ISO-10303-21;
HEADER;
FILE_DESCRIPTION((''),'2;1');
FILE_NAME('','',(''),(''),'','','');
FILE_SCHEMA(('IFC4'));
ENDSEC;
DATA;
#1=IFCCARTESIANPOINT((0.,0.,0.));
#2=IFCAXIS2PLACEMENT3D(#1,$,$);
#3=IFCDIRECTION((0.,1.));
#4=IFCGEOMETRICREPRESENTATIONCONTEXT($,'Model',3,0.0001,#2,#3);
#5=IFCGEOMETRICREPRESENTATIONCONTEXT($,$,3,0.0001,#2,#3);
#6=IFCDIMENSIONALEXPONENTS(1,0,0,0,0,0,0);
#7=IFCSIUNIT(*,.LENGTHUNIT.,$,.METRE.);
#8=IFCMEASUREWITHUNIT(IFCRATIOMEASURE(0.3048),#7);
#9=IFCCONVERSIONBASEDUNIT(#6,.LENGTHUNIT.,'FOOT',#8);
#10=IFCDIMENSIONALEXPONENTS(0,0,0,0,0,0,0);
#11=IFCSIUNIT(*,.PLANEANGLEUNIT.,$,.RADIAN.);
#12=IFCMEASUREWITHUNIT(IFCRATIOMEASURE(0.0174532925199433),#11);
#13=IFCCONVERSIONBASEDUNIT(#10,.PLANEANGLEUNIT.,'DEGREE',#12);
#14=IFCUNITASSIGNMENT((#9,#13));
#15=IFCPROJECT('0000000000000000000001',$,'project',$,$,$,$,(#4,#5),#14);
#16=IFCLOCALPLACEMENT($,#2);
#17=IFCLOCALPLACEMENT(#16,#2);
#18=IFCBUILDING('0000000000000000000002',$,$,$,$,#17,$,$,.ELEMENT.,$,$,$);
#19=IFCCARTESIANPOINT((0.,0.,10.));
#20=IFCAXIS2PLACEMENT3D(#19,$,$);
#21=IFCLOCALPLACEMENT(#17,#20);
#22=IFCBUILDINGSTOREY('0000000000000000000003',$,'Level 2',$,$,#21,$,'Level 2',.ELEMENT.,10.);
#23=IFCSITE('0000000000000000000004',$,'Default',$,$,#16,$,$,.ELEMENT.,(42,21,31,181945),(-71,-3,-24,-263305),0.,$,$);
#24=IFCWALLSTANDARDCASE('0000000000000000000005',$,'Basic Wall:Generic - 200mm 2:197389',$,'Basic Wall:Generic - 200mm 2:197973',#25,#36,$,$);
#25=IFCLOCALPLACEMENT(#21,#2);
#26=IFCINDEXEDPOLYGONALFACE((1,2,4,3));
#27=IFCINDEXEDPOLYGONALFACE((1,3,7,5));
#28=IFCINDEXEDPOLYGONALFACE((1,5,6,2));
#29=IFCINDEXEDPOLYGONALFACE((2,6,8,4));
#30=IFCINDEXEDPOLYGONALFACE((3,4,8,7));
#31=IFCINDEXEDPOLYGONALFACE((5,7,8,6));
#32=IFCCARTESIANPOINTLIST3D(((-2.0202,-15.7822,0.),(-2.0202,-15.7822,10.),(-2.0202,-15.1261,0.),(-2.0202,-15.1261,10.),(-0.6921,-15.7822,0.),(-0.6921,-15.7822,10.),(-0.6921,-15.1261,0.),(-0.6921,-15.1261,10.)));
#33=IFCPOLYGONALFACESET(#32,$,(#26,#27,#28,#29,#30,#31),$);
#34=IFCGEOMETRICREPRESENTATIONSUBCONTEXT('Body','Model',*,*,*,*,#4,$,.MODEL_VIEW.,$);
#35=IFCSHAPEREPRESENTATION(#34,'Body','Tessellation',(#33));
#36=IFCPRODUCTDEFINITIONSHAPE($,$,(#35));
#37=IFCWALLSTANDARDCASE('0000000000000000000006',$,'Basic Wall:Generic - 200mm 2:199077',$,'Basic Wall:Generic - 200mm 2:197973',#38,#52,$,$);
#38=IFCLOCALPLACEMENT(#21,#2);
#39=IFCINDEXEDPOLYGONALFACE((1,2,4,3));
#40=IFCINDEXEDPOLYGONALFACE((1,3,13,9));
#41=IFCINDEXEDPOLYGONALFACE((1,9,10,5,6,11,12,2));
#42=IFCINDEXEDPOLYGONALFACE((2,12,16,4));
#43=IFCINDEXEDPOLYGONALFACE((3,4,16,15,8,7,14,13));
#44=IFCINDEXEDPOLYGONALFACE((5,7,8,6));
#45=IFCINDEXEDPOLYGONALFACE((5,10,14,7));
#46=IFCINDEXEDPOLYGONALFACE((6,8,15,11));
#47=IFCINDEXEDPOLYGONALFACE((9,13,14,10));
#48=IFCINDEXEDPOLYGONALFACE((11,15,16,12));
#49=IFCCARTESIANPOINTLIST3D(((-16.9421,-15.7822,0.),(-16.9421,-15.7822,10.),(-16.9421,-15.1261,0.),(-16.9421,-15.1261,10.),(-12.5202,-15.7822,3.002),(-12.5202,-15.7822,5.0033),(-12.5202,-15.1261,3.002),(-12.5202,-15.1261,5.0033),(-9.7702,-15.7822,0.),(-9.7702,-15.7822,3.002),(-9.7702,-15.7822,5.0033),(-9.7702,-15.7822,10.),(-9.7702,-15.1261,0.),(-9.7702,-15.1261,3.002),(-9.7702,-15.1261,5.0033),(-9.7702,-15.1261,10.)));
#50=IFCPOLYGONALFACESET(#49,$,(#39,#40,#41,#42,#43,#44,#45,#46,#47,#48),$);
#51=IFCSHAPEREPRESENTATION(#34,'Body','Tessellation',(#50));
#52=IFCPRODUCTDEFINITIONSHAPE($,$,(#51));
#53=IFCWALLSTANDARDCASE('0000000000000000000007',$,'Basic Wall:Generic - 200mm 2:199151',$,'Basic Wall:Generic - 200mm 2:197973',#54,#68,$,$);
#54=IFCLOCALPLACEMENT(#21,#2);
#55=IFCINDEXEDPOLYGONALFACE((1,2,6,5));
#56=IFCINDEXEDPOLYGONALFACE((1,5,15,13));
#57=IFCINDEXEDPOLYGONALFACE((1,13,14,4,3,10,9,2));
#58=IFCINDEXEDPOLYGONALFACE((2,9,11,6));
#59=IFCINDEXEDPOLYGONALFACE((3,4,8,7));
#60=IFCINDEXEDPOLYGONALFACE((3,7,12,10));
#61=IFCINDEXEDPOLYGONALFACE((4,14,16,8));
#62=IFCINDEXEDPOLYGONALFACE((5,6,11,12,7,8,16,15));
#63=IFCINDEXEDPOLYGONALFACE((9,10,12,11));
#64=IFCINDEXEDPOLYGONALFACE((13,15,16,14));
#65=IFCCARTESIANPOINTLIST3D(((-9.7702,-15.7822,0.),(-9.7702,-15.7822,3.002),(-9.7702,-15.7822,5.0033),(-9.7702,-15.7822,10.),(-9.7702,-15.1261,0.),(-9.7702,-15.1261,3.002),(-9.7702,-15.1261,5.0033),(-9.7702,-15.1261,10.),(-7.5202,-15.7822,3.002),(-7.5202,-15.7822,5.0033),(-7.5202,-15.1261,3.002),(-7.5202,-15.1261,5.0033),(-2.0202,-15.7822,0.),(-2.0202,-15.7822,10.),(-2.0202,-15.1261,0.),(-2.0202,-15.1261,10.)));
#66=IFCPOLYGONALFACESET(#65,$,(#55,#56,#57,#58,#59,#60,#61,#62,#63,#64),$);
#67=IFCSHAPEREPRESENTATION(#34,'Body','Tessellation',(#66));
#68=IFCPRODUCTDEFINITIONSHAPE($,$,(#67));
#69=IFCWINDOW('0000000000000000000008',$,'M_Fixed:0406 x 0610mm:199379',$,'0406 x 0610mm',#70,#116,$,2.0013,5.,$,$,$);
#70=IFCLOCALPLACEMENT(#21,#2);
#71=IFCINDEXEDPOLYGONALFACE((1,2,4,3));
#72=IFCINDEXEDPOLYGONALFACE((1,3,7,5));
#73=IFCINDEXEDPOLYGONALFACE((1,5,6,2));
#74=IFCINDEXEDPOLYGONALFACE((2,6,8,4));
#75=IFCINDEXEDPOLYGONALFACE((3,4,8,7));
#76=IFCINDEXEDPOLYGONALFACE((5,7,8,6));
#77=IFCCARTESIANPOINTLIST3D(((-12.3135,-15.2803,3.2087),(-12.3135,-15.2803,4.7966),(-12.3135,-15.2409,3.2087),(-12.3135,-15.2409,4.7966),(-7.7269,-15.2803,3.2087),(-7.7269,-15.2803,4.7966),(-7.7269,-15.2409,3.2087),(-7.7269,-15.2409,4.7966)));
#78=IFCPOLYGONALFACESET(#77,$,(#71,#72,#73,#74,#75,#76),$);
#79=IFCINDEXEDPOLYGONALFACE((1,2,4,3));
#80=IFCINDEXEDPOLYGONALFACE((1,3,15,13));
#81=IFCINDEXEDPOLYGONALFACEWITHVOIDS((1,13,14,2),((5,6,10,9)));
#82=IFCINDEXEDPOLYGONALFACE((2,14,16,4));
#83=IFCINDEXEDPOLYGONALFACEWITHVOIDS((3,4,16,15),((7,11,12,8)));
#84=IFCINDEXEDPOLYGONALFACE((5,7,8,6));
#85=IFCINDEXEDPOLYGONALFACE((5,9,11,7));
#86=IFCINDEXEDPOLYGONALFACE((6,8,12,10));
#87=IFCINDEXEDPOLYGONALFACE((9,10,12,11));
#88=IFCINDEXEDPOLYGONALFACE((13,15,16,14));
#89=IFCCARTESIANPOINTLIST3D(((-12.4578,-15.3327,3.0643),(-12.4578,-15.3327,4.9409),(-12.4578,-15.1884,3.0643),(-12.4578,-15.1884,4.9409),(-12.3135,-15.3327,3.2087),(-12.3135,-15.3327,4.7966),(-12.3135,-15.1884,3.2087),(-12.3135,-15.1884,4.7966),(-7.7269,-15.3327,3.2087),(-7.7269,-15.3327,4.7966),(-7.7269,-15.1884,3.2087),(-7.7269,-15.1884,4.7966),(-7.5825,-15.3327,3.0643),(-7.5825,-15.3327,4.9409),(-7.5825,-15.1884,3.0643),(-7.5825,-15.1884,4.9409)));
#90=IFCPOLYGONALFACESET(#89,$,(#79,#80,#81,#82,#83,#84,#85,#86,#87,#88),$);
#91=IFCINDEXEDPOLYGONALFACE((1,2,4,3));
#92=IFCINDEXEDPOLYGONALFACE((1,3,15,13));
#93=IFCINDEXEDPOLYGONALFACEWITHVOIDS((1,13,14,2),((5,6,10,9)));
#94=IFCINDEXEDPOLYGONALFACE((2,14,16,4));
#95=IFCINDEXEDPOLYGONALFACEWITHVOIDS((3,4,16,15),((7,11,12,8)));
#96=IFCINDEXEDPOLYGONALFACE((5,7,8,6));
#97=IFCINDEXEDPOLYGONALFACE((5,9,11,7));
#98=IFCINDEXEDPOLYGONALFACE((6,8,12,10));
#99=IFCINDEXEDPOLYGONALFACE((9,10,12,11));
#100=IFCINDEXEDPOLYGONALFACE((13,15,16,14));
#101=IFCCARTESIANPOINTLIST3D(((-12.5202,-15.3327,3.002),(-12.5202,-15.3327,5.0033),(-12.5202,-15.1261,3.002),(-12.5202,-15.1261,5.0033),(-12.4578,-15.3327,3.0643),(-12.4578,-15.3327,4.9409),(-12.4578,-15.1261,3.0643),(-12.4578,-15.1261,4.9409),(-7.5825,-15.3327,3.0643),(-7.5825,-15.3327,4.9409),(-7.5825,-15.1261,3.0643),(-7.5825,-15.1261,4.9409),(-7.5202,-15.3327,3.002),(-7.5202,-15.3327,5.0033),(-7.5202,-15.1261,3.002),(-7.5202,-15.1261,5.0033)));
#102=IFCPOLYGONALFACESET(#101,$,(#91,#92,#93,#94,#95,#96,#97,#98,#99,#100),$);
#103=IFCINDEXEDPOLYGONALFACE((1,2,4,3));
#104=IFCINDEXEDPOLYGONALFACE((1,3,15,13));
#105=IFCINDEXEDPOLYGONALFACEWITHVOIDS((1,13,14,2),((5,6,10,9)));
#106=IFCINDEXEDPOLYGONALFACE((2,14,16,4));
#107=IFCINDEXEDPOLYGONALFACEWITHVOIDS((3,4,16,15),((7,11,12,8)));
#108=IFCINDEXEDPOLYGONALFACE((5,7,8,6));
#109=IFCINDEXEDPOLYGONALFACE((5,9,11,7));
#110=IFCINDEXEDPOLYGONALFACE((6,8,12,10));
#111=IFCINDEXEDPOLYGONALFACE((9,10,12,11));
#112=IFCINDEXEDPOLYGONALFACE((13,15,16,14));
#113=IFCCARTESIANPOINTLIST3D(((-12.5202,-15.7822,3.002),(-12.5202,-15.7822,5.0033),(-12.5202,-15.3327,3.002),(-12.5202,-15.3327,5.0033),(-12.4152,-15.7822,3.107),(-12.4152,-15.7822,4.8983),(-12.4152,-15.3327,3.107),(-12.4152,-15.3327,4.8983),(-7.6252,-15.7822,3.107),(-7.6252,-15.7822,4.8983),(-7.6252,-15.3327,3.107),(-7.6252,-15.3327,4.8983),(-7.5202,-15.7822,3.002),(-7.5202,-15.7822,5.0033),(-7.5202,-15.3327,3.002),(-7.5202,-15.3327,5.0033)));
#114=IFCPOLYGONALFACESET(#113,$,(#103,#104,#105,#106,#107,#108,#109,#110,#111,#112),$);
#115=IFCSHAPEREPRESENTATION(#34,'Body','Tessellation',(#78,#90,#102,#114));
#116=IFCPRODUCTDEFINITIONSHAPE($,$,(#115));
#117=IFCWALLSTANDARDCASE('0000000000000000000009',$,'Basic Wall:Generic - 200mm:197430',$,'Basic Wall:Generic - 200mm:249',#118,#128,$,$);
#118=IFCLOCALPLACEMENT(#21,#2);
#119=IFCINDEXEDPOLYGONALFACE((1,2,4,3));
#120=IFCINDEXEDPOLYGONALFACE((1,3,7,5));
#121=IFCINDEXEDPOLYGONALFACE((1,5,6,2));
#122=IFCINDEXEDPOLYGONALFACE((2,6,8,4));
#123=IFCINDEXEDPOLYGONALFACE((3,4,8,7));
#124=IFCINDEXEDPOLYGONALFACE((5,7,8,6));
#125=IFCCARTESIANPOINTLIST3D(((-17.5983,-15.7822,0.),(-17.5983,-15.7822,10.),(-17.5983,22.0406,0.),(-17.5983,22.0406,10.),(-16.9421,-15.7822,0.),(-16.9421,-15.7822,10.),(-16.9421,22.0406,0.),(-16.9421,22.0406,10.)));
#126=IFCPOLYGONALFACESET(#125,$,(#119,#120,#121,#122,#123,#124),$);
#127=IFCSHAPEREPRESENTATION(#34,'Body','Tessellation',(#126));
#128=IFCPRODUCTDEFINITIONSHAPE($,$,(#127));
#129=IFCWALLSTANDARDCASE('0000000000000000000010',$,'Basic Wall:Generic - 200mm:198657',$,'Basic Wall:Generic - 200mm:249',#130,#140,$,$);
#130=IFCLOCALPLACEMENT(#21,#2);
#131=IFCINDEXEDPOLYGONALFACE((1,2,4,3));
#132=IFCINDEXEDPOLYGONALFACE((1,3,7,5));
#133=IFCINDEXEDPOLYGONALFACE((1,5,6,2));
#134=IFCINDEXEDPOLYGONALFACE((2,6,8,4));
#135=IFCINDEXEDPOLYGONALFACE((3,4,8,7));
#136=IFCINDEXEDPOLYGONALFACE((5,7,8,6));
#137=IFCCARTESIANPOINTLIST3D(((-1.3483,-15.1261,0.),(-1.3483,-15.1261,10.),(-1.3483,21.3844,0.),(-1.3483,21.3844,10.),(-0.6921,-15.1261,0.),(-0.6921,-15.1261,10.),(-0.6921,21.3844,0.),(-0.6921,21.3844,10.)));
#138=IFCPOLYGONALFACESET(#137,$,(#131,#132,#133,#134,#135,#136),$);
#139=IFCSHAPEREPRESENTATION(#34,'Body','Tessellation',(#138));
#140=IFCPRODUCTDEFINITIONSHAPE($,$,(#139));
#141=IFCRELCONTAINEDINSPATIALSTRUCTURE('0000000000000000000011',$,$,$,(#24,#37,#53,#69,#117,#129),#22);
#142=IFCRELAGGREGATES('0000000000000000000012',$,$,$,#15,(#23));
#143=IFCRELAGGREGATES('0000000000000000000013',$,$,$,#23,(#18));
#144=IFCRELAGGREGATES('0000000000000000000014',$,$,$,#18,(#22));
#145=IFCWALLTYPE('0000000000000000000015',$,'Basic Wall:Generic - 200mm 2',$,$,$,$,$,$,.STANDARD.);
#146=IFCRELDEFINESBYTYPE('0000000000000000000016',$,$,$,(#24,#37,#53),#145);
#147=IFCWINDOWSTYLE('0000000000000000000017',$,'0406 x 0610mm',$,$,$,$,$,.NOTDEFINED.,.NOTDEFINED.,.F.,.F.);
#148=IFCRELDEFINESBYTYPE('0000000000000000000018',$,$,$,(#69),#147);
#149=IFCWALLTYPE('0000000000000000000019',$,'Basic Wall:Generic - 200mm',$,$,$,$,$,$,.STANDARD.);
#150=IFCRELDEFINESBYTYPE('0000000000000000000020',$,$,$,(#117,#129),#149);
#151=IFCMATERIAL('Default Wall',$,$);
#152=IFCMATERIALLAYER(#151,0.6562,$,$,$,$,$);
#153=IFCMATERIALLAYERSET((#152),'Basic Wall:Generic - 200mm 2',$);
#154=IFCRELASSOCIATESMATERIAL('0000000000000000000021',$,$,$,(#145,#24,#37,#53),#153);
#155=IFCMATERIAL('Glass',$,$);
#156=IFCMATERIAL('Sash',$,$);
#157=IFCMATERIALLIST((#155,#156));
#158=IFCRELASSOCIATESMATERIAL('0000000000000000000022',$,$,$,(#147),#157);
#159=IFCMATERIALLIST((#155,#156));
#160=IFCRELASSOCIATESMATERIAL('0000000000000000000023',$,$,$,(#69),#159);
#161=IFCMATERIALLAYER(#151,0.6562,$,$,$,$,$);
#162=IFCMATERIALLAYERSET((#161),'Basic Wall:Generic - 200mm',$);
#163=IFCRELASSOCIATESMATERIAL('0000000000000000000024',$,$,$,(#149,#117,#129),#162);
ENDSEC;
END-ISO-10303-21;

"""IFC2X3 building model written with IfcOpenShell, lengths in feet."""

from ifc_helpers import new_model, entity, si_unit, converted_unit, direction, frame, frame_2d, origin, place, context, subcontext, project, spatial, polyline, rectangle, outline, extrude, clip, halfspace, source, transform, mapped, material, material_list, layer, layer_set, layer_usage, type_object, type_shapes, element, fill, save


model = new_model("IFC2X3")

# Units and contexts
model_context = context("Model", 3, precision=0.0001, world=origin(), true_north=direction((0.0, 1.0)))
context_of_model = context(None, 3, precision=0.0001, world=origin(), true_north=direction((0.0, 1.0)))
body_context = subcontext(model_context, "Body", "Model", "MODEL_VIEW")
ifc_project = project(units=[converted_unit("LENGTHUNIT", "FOOT", entity("IfcRatioMeasure", 0.3048), si_unit("LENGTHUNIT", "METRE"), dimensions=[1, 0, 0, 0, 0, 0, 0]), converted_unit("PLANEANGLEUNIT", "DEGREE", entity("IfcRatioMeasure", 0.0174532925199433), si_unit("PLANEANGLEUNIT", "RADIAN"), dimensions=[0, 0, 0, 0, 0, 0, 0])], contexts=[model_context, context_of_model])

# Site, building, storey
site_placement = place(None, origin())
site = spatial("IfcSite", under=ifc_project, at=site_placement, Name="Default", CompositionType="ELEMENT", RefLatitude=(42, 21, 31, 181945), RefLongitude=(-71, -3, -24, -263305), RefElevation=0.0)
building_placement = place(site_placement, origin())
building = spatial("IfcBuilding", under=site, at=building_placement, CompositionType="ELEMENT")
storey_placement = place(building_placement, frame((0.0, 0.0, 10.0)))
storey = spatial("IfcBuildingStorey", under=building, at=storey_placement, Name="Level 2", LongName="Level 2", CompositionType="ELEMENT", Elevation=10.0)

# Wall
ifc_material_1 = material(Name="Default Wall")
ifc_layer_1 = layer(ifc_material_1, 0.6562)
ifc_layer_set_1 = layer_set([ifc_layer_1], Name="Basic Wall:Generic - 200mm 2")
ifc_layer_usage_1 = layer_usage(ifc_layer_set_1, "AXIS2", "NEGATIVE", 0.3281)
wall_type_1 = type_object("IfcWallType", Name="Basic Wall:Generic - 200mm 2", PredefinedType="STANDARD", material=ifc_layer_set_1)
wall_1_placement = place(storey_placement, frame((-0.6921, -15.4541, 0.0), z_axis=(0.0, 0.0, 1.0), x_axis=(-1.0, 0.0, 0.0)))
element("IfcWallStandardCase", 1, at=wall_1_placement, inside=storey, type_object=wall_type_1, material=ifc_layer_usage_1, Name="Basic Wall:Generic - 200mm 2:197389", ObjectType="Basic Wall:Generic - 200mm 2:197973", context=body_context, shape_type="Clipping", body=[
    clip(extrude(rectangle(XDim=1.3281, YDim=0.6562, at=frame_2d((0.664, 0.0), x_axis=(-1.0, 0.0))), origin(), (0.0, 0.0, 1.0), 10.0), halfspace(frame((0.0, 0.0, -10.0)), True)),
])

# Wall, opening
ifc_layer_usage_2 = layer_usage(ifc_layer_set_1, "AXIS2", "NEGATIVE", 0.3281)
wall_2_placement = place(storey_placement, frame((-9.7702, -15.4541, 0.0), z_axis=(0.0, 0.0, 1.0), x_axis=(-1.0, 0.0, 0.0)))
wall_2 = element("IfcWallStandardCase", 2, at=wall_2_placement, inside=storey, type_object=wall_type_1, material=ifc_layer_usage_2, Name="Basic Wall:Generic - 200mm 2:199077", ObjectType="Basic Wall:Generic - 200mm 2:197973", context=body_context, shape_type="Clipping", body=[
    clip(extrude(rectangle(XDim=7.1719, YDim=0.6562, at=frame_2d((3.586, 0.0), x_axis=(-1.0, 0.0))), origin(), (0.0, 0.0, 1.0), 10.0), halfspace(frame((0.0, 0.0, -10.0)), True)),
])
opening_1_placement = place(wall_2_placement, origin())
element("IfcOpeningElement", 3, at=opening_1_placement, cuts=wall_2, ObjectType="Opening", context=body_context, shape_type="SweptSolid", body=[
    extrude(rectangle(XDim=2.0013, YDim=5.0, at=frame_2d((0.0, 0.0), x_axis=(0.0, 1.0))), frame((0.25, -4.6719, 4.0026), z_axis=(0.0, 1.0, 0.0), x_axis=(-1.0, 0.0, 0.0)), (0.0, 0.0, 1.0), 10.0),
])

# Wall, opening, window
ifc_layer_usage_3 = layer_usage(ifc_layer_set_1, "AXIS2", "NEGATIVE", 0.3281)
wall_3_placement = place(storey_placement, frame((-2.0202, -15.4541, 0.0), z_axis=(0.0, 0.0, 1.0), x_axis=(-1.0, 0.0, 0.0)))
wall_3 = element("IfcWallStandardCase", 4, at=wall_3_placement, inside=storey, type_object=wall_type_1, material=ifc_layer_usage_3, Name="Basic Wall:Generic - 200mm 2:199151", ObjectType="Basic Wall:Generic - 200mm 2:197973", context=body_context, shape_type="Clipping", body=[
    clip(extrude(rectangle(XDim=7.75, YDim=0.6562, at=frame_2d((3.875, 0.0), x_axis=(-1.0, 0.0))), origin(), (0.0, 0.0, 1.0), 10.0), halfspace(frame((0.0, 0.0, -10.0)), True)),
])
opening_2_placement = place(wall_3_placement, frame((10.5, 0.3281, 3.002)))
opening_2 = element("IfcOpeningElement", 5, at=opening_2_placement, cuts=wall_3, ObjectType="Opening", context=body_context, shape_type="SweptSolid", body=[
    extrude(rectangle(XDim=2.0013, YDim=5.0, at=frame_2d((1.0007, 2.5), x_axis=(1.0, 0.0))), frame((0.0, 0.0, 0.0), z_axis=(0.0, -1.0, 0.0), x_axis=(0.0, 0.0, 1.0)), (0.0, 0.0, 1.0), 0.6562),
])
ifc_material_2 = material(Name="Glass")
ifc_material_3 = material(Name="Sash")
ifc_material_list_1 = material_list([ifc_material_2, ifc_material_3])
ifc_material_list_2 = material_list([ifc_material_2, ifc_material_3])
window_style_1 = type_object("IfcWindowStyle", Name="0406 x 0610mm", ConstructionType="NOTDEFINED", OperationType="NOTDEFINED", ParameterTakesPrecedence=False, Sizeable=False, material=ifc_material_list_2)
shared_shape_1 = source(origin(), body_context, "Body", "SweptSolid", [
    extrude(rectangle(XDim=0.0394, YDim=4.5866, at=frame_2d((0.0, 0.0), x_axis=(1.0, 0.0))), frame((2.5, 0.5217, 0.2067), z_axis=(0.0, 0.0, 1.0), x_axis=(0.0, -1.0, 0.0)), (0.0, 0.0, 1.0), 1.5879),
    extrude(outline(polyline([(-2.4377, -0.9383), (2.4377, -0.9383), (2.4377, 0.9383), (-2.4377, 0.9383), (-2.4377, -0.9383)]), holes=[polyline([(-2.2933, -0.794), (-2.2933, 0.794), (2.2933, 0.794), (2.2933, -0.794), (-2.2933, -0.794)])]), frame((2.5, 0.4495, 1.0007), z_axis=(0.0, 1.0, 0.0), x_axis=(1.0, 0.0, 0.0)), (0.0, 0.0, 1.0), 0.1444),
    extrude(outline(polyline([(-2.5, -1.0007), (2.5, -1.0007), (2.5, 1.0007), (-2.5, 1.0007), (-2.5, -1.0007)]), holes=[polyline([(-2.4377, -0.9383), (-2.4377, 0.9383), (2.4377, 0.9383), (2.4377, -0.9383), (-2.4377, -0.9383)])]), frame((2.5, 0.4495, 1.0007), z_axis=(0.0, 1.0, 0.0), x_axis=(1.0, 0.0, 0.0)), (0.0, 0.0, 1.0), 0.2067),
    extrude(outline(polyline([(-2.5, -1.0007), (2.5, -1.0007), (2.5, 1.0007), (-2.5, 1.0007), (-2.5, -1.0007)]), holes=[polyline([(-2.395, -0.8957), (-2.395, 0.8957), (2.395, 0.8957), (2.395, -0.8957), (-2.395, -0.8957)])]), frame((2.5, 0.0, 1.0007), z_axis=(0.0, 1.0, 0.0), x_axis=(1.0, 0.0, 0.0)), (0.0, 0.0, 1.0), 0.4495),
])
type_shapes(window_style_1, [shared_shape_1])
window_1_placement = place(opening_2_placement, frame((0.0, 0.0, 0.0), z_axis=(0.0, 0.0, 1.0), x_axis=(-1.0, 0.0, 0.0)))
window_1 = element("IfcWindow", 6, at=window_1_placement, inside=storey, type_object=window_style_1, material=ifc_material_list_1, Name="M_Fixed:0406 x 0610mm:199379", ObjectType="0406 x 0610mm", OverallHeight=2.0013, OverallWidth=5.0, context=body_context, shape_type="MappedRepresentation", body=[
    mapped(shared_shape_1, transform((0.0, 0.0, 0.0), scale=1.0)),
])
fill(opening_2, window_1)

# Walls
ifc_layer_2 = layer(ifc_material_1, 0.6562)
ifc_layer_set_2 = layer_set([ifc_layer_2], Name="Basic Wall:Generic - 200mm")
ifc_layer_usage_4 = layer_usage(ifc_layer_set_2, "AXIS2", "NEGATIVE", 0.3281)
wall_type_2 = type_object("IfcWallType", Name="Basic Wall:Generic - 200mm", PredefinedType="STANDARD", material=ifc_layer_set_2)
wall_4_placement = place(storey_placement, frame((-17.2702, -15.7822, 0.0), z_axis=(0.0, 0.0, 1.0), x_axis=(0.0, 1.0, 0.0)))
element("IfcWallStandardCase", 7, at=wall_4_placement, inside=storey, type_object=wall_type_2, material=ifc_layer_usage_4, Name="Basic Wall:Generic - 200mm:197430", ObjectType="Basic Wall:Generic - 200mm:249", context=body_context, shape_type="Clipping", body=[
    clip(extrude(rectangle(XDim=37.8228, YDim=0.6562, at=frame_2d((18.9114, 0.0), x_axis=(-1.0, 0.0))), origin(), (0.0, 0.0, 1.0), 10.0), halfspace(frame((0.0, 0.0, -10.0)), True)),
])
ifc_layer_usage_5 = layer_usage(ifc_layer_set_2, "AXIS2", "NEGATIVE", 0.3281)
wall_5_placement = place(storey_placement, frame((-1.0202, -15.1261, 0.0), z_axis=(0.0, 0.0, 1.0), x_axis=(0.0, 1.0, 0.0)))
element("IfcWallStandardCase", 8, at=wall_5_placement, inside=storey, type_object=wall_type_2, material=ifc_layer_usage_5, Name="Basic Wall:Generic - 200mm:198657", ObjectType="Basic Wall:Generic - 200mm:249", context=body_context, shape_type="Clipping", body=[
    clip(extrude(rectangle(XDim=36.5105, YDim=0.6562, at=frame_2d((18.2552, 0.0), x_axis=(-1.0, 0.0))), origin(), (0.0, 0.0, 1.0), 10.0), halfspace(frame((0.0, 0.0, -10.0)), True)),
])

save(model, "model.ifc")
